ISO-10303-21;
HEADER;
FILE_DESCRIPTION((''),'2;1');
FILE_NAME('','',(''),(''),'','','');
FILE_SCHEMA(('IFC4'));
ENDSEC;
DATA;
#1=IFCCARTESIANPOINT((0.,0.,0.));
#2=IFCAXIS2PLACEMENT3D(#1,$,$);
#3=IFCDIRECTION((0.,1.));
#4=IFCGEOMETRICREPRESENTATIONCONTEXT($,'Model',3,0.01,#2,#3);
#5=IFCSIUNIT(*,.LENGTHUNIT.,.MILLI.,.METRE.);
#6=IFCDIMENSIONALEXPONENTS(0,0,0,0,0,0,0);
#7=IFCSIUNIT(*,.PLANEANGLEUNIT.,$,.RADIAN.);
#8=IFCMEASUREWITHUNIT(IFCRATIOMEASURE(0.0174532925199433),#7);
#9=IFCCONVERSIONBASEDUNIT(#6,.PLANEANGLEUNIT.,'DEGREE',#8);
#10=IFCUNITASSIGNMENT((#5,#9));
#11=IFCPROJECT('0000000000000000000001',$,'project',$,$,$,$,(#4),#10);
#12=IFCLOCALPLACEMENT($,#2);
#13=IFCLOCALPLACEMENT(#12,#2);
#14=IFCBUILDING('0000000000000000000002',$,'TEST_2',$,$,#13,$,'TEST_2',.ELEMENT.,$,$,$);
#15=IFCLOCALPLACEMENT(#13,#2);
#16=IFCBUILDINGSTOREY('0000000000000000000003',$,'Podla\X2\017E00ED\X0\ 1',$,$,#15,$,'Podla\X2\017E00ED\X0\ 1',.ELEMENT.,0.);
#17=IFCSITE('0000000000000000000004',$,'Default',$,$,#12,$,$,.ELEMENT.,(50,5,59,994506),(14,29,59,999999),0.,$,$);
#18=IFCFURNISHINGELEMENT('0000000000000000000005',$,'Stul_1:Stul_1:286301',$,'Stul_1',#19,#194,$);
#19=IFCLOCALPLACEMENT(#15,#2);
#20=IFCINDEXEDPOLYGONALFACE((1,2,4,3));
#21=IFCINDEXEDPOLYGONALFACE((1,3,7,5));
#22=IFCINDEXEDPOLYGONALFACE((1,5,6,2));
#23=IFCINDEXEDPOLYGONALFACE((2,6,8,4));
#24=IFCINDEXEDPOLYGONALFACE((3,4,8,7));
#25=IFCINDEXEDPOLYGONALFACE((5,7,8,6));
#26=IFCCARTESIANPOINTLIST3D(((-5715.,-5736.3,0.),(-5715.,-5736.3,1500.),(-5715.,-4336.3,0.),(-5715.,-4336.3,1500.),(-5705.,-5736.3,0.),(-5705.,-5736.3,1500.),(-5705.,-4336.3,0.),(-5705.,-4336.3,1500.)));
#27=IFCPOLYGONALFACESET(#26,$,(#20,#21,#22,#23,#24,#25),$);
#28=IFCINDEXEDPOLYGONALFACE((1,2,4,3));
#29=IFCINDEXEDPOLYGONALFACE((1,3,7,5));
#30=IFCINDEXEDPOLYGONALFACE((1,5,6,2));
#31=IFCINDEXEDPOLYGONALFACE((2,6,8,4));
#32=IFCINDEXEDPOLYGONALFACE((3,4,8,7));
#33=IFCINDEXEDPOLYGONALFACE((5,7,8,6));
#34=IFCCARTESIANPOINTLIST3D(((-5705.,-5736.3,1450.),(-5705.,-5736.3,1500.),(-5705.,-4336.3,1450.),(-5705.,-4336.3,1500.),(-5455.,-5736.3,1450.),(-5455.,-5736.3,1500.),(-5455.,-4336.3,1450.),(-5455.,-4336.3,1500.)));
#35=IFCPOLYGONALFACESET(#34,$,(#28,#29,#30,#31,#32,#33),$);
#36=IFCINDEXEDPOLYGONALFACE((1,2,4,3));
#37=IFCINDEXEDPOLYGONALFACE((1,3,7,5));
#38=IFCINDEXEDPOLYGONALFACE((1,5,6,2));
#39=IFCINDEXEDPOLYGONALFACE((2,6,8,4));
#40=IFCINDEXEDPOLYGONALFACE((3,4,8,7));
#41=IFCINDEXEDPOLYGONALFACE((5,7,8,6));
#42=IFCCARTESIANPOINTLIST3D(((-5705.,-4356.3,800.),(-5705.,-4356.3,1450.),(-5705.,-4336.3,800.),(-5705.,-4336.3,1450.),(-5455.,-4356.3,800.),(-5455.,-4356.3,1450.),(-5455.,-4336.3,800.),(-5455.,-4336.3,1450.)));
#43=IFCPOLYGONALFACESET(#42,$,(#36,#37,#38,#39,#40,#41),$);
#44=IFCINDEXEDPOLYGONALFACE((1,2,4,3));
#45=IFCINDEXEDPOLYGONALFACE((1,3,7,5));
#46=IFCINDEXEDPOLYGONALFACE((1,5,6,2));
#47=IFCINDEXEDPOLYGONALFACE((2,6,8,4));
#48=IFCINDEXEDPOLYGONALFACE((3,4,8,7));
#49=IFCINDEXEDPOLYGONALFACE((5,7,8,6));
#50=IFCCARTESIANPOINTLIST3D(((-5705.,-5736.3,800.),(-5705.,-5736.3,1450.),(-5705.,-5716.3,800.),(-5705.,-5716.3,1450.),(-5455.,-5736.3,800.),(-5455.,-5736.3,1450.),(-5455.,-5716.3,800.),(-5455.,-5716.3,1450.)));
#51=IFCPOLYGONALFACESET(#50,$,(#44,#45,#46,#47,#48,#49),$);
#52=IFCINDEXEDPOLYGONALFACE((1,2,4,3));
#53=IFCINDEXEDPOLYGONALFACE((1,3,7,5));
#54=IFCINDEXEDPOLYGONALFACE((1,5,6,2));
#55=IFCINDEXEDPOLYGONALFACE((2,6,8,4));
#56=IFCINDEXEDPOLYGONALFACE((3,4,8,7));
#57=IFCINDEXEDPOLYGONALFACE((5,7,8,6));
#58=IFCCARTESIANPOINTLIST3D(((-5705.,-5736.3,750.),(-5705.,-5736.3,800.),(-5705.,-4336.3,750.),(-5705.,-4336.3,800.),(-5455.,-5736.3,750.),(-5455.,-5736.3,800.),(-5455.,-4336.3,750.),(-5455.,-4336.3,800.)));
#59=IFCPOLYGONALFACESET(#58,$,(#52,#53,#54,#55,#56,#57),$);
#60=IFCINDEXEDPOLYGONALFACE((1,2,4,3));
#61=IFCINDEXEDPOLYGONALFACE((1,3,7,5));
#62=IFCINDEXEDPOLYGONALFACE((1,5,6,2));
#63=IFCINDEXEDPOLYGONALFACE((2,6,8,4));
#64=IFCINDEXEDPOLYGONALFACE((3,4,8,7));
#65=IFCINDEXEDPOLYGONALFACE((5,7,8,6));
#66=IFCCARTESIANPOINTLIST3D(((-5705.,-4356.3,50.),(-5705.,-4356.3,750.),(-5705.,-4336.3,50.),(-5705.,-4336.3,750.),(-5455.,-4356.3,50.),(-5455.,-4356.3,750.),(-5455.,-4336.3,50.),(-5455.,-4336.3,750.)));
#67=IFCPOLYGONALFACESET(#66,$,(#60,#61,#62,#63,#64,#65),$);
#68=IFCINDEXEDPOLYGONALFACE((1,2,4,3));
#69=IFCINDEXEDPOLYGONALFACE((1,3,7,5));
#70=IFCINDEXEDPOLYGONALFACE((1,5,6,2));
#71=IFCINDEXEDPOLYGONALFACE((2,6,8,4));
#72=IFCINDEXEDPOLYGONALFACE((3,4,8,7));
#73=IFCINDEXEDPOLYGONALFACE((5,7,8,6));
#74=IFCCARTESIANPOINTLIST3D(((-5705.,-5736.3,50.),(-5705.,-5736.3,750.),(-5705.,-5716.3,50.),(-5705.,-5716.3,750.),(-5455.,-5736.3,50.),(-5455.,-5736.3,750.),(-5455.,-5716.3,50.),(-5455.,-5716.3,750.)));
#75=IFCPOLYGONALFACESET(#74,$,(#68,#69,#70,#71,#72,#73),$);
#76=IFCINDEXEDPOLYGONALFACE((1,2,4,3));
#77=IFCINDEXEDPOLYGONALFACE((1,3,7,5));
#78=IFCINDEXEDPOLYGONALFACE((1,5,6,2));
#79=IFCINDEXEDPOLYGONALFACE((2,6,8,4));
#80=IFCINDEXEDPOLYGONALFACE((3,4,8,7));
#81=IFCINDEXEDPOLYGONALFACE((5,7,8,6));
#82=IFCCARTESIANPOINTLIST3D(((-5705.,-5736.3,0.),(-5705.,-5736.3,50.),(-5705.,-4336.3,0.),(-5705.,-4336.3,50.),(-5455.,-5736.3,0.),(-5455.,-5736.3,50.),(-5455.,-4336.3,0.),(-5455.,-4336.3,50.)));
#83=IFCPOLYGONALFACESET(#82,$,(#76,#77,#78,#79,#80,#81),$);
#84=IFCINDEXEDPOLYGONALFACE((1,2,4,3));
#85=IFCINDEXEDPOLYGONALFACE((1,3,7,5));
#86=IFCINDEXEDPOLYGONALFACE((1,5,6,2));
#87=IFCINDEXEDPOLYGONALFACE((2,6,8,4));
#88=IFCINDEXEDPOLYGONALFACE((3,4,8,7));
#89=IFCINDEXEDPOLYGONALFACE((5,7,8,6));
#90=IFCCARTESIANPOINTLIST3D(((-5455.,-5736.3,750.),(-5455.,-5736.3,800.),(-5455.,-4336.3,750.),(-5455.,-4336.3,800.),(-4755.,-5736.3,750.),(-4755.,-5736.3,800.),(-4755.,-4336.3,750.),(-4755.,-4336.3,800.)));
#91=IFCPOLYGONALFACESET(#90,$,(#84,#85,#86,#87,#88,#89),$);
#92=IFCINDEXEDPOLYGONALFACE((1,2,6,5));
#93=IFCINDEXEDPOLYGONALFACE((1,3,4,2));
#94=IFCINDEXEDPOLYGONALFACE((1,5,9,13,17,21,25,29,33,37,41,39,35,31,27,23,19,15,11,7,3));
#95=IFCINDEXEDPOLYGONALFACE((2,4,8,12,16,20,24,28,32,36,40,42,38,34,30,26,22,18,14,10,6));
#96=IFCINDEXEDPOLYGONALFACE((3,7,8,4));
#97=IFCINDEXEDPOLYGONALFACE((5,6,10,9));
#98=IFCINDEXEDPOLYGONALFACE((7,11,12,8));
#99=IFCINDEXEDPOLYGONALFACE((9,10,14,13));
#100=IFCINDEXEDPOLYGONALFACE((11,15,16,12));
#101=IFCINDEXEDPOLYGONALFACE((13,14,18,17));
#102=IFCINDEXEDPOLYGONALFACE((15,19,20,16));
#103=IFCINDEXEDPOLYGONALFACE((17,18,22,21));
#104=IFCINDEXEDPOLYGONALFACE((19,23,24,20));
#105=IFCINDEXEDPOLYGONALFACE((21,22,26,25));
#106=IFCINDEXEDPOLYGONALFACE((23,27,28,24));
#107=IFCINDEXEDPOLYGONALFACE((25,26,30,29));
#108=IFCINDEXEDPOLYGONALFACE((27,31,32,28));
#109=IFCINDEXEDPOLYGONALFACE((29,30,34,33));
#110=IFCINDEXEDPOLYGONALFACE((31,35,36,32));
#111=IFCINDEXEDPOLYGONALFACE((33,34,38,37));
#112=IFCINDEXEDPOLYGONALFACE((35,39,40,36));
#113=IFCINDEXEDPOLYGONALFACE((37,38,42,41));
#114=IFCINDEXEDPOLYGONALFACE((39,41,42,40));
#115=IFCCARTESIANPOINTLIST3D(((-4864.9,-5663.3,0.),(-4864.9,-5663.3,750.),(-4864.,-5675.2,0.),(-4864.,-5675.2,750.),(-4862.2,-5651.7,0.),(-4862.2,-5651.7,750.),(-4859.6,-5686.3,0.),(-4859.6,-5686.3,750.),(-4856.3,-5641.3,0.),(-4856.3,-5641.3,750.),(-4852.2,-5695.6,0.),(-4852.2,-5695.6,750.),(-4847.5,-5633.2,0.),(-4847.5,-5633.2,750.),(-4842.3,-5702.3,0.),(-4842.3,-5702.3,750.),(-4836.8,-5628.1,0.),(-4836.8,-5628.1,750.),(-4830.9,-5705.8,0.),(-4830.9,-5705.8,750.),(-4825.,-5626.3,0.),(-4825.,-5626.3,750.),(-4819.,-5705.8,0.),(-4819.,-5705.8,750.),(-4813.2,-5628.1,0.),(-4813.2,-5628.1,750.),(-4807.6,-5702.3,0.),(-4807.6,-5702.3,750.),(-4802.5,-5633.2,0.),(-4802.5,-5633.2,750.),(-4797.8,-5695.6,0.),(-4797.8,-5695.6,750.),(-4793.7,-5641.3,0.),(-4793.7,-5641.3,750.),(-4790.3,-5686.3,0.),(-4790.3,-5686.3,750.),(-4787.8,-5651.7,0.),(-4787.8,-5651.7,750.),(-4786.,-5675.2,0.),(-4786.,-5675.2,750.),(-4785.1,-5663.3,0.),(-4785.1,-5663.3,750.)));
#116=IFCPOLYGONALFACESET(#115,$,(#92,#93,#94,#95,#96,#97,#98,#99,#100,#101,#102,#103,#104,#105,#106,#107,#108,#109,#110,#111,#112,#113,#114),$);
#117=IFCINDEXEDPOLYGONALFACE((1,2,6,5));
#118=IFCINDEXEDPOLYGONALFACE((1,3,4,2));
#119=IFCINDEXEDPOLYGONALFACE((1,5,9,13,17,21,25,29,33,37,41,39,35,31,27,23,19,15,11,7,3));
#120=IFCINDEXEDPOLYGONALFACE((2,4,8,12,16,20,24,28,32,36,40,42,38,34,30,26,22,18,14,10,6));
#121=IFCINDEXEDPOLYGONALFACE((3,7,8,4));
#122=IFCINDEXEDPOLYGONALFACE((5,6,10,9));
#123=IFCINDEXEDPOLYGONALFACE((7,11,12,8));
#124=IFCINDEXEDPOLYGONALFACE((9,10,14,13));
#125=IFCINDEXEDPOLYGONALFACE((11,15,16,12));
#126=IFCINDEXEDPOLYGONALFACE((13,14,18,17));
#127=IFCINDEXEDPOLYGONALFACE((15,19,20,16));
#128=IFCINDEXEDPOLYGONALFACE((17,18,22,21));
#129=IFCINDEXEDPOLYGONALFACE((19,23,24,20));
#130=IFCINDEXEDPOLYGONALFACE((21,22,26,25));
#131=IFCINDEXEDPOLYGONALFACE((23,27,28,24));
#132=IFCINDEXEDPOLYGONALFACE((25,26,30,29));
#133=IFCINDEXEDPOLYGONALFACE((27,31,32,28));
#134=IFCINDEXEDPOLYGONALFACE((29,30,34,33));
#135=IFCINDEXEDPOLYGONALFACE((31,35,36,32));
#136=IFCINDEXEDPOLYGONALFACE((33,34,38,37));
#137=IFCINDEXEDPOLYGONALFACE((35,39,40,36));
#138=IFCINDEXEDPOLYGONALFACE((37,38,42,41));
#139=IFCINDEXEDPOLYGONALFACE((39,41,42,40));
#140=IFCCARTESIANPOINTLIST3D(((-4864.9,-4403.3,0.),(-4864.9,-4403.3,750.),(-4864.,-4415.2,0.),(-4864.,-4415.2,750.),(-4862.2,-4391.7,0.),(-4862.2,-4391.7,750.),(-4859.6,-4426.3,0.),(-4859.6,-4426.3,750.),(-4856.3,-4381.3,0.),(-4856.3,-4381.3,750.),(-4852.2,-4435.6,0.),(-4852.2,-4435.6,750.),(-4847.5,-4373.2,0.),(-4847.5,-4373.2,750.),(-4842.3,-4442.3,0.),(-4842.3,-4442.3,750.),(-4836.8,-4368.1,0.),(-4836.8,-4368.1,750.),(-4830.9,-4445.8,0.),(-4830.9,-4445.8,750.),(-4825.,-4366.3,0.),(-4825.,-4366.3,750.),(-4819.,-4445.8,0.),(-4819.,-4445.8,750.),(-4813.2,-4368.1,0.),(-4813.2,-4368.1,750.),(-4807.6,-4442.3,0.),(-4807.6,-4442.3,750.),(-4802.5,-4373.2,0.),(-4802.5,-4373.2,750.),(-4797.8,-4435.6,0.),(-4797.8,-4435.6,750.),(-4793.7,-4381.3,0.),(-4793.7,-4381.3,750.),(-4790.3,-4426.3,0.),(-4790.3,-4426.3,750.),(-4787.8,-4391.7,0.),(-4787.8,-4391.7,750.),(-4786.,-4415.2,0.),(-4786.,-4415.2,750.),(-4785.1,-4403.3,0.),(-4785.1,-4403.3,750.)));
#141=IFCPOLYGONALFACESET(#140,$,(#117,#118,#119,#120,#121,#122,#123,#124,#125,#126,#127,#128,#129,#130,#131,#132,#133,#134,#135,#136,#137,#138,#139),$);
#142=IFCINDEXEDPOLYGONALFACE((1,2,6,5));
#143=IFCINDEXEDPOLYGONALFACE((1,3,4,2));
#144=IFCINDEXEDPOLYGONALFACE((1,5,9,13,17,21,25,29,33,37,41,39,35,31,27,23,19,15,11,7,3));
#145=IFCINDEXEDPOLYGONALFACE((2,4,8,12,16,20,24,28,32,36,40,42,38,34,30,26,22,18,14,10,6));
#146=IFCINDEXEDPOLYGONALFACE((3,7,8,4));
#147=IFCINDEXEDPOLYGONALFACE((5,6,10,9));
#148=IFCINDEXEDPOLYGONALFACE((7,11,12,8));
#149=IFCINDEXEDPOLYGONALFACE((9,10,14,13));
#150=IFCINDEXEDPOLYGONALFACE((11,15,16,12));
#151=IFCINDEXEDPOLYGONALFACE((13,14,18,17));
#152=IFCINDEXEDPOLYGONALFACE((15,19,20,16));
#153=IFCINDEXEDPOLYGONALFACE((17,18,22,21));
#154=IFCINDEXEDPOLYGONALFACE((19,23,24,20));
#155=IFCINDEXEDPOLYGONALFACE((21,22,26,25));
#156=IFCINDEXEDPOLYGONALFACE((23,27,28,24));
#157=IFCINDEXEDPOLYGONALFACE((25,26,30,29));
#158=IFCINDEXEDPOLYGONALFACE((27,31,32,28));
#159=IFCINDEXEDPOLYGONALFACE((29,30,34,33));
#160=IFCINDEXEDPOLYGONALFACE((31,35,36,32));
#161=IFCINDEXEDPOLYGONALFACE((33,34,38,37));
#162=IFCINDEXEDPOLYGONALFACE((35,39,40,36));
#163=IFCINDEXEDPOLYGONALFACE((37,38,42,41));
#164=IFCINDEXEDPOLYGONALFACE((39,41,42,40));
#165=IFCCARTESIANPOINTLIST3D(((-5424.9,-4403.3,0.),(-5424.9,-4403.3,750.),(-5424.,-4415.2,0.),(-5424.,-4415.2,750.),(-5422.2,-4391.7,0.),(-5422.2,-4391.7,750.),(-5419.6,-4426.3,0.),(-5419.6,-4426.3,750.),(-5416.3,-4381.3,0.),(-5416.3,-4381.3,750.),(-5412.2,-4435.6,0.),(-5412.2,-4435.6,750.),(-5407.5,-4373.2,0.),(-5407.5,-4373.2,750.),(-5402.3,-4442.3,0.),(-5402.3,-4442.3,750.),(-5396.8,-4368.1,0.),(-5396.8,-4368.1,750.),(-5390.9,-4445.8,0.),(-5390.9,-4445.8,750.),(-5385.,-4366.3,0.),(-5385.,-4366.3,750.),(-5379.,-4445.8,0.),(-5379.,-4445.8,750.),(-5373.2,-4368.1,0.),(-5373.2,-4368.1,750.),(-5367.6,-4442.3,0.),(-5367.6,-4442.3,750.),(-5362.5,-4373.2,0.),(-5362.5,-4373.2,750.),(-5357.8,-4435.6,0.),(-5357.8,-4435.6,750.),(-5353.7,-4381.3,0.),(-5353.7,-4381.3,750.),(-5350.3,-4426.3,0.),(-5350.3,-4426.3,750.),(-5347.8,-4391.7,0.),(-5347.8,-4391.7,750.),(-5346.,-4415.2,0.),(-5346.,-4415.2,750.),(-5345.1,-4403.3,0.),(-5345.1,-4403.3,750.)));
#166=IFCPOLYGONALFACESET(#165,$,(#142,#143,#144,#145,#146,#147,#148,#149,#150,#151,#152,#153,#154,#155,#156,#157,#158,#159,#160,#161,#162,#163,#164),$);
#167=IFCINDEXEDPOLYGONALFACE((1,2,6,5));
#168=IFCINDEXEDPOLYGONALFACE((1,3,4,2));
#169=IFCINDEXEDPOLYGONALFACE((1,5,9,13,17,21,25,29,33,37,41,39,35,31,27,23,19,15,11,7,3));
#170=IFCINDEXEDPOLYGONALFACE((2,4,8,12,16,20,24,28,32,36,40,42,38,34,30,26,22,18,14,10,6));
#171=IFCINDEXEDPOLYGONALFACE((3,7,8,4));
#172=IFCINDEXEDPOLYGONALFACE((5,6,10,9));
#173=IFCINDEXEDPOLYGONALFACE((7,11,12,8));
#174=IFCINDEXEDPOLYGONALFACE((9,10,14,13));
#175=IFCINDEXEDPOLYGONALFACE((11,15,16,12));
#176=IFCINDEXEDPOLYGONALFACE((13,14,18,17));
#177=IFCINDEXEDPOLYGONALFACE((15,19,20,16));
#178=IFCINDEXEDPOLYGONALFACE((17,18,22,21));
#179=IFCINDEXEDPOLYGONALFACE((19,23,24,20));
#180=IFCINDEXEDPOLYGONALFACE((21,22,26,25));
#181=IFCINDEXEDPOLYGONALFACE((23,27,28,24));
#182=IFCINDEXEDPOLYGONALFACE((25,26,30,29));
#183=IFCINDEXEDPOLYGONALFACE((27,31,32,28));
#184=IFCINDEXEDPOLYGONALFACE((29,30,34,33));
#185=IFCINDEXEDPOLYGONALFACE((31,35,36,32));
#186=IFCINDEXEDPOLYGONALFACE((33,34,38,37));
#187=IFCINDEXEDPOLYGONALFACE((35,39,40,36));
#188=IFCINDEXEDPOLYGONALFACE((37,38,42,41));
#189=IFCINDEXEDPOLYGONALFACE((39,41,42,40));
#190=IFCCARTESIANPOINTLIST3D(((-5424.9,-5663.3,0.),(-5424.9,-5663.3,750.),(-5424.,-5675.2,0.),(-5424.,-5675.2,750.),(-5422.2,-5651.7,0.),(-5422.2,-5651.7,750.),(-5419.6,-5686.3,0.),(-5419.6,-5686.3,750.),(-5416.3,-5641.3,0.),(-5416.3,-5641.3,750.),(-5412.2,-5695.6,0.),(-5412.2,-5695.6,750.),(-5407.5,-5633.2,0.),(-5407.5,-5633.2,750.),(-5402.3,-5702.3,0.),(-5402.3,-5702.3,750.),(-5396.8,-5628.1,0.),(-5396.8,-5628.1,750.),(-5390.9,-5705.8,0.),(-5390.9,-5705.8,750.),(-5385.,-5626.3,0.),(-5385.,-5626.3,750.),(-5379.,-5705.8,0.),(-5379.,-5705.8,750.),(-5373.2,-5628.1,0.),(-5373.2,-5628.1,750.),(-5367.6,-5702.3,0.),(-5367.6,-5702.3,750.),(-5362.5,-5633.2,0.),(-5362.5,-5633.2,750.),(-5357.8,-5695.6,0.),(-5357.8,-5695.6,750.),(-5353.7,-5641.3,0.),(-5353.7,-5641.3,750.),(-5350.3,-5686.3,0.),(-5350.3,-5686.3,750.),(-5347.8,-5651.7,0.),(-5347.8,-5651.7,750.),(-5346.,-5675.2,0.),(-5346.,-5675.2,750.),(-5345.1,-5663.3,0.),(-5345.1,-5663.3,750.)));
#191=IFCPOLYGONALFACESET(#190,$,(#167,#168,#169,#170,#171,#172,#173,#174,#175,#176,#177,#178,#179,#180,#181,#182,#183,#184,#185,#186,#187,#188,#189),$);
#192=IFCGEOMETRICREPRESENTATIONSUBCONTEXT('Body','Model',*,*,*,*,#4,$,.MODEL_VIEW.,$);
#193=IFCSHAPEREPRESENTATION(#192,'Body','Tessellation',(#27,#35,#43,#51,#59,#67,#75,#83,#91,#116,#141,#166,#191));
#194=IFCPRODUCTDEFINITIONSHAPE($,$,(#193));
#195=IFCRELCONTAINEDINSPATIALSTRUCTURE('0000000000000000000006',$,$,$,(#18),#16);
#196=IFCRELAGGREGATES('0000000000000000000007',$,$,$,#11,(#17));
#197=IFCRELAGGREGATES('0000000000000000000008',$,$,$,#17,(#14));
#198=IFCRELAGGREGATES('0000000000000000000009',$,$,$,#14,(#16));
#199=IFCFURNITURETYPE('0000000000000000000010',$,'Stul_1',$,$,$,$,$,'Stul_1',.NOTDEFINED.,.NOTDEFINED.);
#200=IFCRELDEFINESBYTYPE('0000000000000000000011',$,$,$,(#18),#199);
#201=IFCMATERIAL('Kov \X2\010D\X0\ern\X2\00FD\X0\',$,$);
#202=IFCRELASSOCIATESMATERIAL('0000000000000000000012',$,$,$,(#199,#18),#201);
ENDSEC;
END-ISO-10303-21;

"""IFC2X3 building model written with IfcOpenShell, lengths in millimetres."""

from ifc_helpers import new_model, entity, si_unit, converted_unit, direction, frame, frame_2d, origin, origin_2d_with_axis, place, context, subcontext, project, spatial, rectangle, circle, extrude, source, transform, mapped, material, type_object, type_shapes, element, save


model = new_model("IFC2X3")

# Units and contexts
model_context = context("Model", 3, precision=0.01, world=origin(), true_north=direction((0.0, 1.0)))
body_context = subcontext(model_context, "Body", "Model", "MODEL_VIEW")
ifc_project = project(units=[si_unit("LENGTHUNIT", "METRE", prefix="MILLI"), converted_unit("PLANEANGLEUNIT", "DEGREE", entity("IfcRatioMeasure", 0.0174532925199433), si_unit("PLANEANGLEUNIT", "RADIAN"), dimensions=[0, 0, 0, 0, 0, 0, 0])], contexts=[model_context])

# Site, building, storey
site_placement = place(None, origin())
site = spatial("IfcSite", under=ifc_project, at=site_placement, Name="Default", CompositionType="ELEMENT", RefLatitude=(50, 5, 59, 994506), RefLongitude=(14, 29, 59, 999999), RefElevation=0.0)
building_placement = place(site_placement, origin())
building = spatial("IfcBuilding", under=site, at=building_placement, Name="TEST_2", LongName="TEST_2", CompositionType="ELEMENT")
storey_placement = place(building_placement, origin())
storey = spatial("IfcBuildingStorey", under=building, at=storey_placement, Name="Podlaží 1", LongName="Podlaží 1", CompositionType="ELEMENT", Elevation=0.0)

# Furnishing element
ifc_material = material(Name="Kov černý")
furniture_type = type_object("IfcFurnitureType", Name="Stul_1", ElementType="Stul_1", material=ifc_material)
shared_shape = source(origin(), body_context, "Body", "SweptSolid", [
    extrude(rectangle(XDim=1400.0, YDim=10.0, at=origin_2d_with_axis()), frame((0.0, 605.0, 0.0), z_axis=(0.0, 0.0, 1.0), x_axis=(-1.0, 0.0, 0.0)), (0.0, 0.0, 1.0), 1500.0),
    extrude(rectangle(XDim=1400.0, YDim=250.0, at=frame_2d((0.0, 0.0), x_axis=(1.0, 0.0))), frame((0.0, 475.0, 1450.0), z_axis=(0.0, 0.0, 1.0), x_axis=(-1.0, 0.0, 0.0)), (0.0, 0.0, 1.0), 50.0),
    extrude(rectangle(XDim=20.0, YDim=250.0, at=origin_2d_with_axis()), frame((690.0, 475.0, 800.0), z_axis=(0.0, 0.0, 1.0), x_axis=(-1.0, 0.0, 0.0)), (0.0, 0.0, 1.0), 650.0),
    extrude(rectangle(XDim=20.0, YDim=250.0, at=frame_2d((0.0, 0.0), x_axis=(1.0, 0.0))), frame((-690.0, 475.0, 800.0), z_axis=(0.0, 0.0, 1.0), x_axis=(-1.0, 0.0, 0.0)), (0.0, 0.0, 1.0), 650.0),
    extrude(rectangle(XDim=1400.0, YDim=250.0, at=origin_2d_with_axis()), frame((0.0, 475.0, 750.0), z_axis=(0.0, 0.0, 1.0), x_axis=(-1.0, 0.0, 0.0)), (0.0, 0.0, 1.0), 50.0),
    extrude(rectangle(XDim=20.0, YDim=250.0, at=origin_2d_with_axis()), frame((690.0, 475.0, 50.0), z_axis=(0.0, 0.0, 1.0), x_axis=(-1.0, 0.0, 0.0)), (0.0, 0.0, 1.0), 700.0),
    extrude(rectangle(XDim=20.0, YDim=250.0, at=frame_2d((0.0, 0.0), x_axis=(1.0, 0.0))), frame((-690.0, 475.0, 50.0), z_axis=(0.0, 0.0, 1.0), x_axis=(-1.0, 0.0, 0.0)), (0.0, 0.0, 1.0), 700.0),
    extrude(rectangle(XDim=1400.0, YDim=250.0, at=origin_2d_with_axis()), frame((0.0, 475.0, 0.0), z_axis=(0.0, 0.0, 1.0), x_axis=(-1.0, 0.0, 0.0)), (0.0, 0.0, 1.0), 50.0),
    extrude(rectangle(XDim=1400.0, YDim=700.0, at=origin_2d_with_axis()), frame((0.0, 0.0, 750.0), z_axis=(0.0, 0.0, 1.0), x_axis=(-1.0, 0.0, 0.0)), (0.0, 0.0, 1.0), 50.0),
    extrude(circle(Radius=40.0, at=frame_2d((0.0, 0.0), x_axis=(1.0, 0.0))), frame((-630.0, -280.0, 0.0)), (0.0, 0.0, 1.0), 750.0),
    extrude(circle(Radius=40.0, at=frame_2d((0.0, 0.0), x_axis=(1.0, 0.0))), frame((630.0, -280.0, 0.0)), (0.0, 0.0, 1.0), 750.0),
    extrude(circle(Radius=40.0, at=frame_2d((0.0, 0.0), x_axis=(1.0, 0.0))), frame((630.0, 280.0, 0.0)), (0.0, 0.0, 1.0), 750.0),
    extrude(circle(Radius=40.0, at=frame_2d((0.0, 0.0), x_axis=(1.0, 0.0))), frame((-630.0, 280.0, 0.0)), (0.0, 0.0, 1.0), 750.0),
])
type_shapes(furniture_type, [shared_shape])
for number, where, z_axis, x_axis, name in (
    (1, (-5105.0, -5036.3, 0.0), (0.0, 0.0, 1.0), (0.0, 1.0, 0.0), "Stul_1:Stul_1:286301"),
):
    element("IfcFurnishingElement", number, at=place(storey_placement, frame(where, z_axis=z_axis, x_axis=x_axis)), inside=storey, type_object=furniture_type, material=ifc_material, Name=name, ObjectType="Stul_1", context=body_context, shape_type="MappedRepresentation", body=[
        mapped(shared_shape, transform((0.0, 0.0, 0.0), scale=1.0)),
    ])

save(model, "model.ifc")
